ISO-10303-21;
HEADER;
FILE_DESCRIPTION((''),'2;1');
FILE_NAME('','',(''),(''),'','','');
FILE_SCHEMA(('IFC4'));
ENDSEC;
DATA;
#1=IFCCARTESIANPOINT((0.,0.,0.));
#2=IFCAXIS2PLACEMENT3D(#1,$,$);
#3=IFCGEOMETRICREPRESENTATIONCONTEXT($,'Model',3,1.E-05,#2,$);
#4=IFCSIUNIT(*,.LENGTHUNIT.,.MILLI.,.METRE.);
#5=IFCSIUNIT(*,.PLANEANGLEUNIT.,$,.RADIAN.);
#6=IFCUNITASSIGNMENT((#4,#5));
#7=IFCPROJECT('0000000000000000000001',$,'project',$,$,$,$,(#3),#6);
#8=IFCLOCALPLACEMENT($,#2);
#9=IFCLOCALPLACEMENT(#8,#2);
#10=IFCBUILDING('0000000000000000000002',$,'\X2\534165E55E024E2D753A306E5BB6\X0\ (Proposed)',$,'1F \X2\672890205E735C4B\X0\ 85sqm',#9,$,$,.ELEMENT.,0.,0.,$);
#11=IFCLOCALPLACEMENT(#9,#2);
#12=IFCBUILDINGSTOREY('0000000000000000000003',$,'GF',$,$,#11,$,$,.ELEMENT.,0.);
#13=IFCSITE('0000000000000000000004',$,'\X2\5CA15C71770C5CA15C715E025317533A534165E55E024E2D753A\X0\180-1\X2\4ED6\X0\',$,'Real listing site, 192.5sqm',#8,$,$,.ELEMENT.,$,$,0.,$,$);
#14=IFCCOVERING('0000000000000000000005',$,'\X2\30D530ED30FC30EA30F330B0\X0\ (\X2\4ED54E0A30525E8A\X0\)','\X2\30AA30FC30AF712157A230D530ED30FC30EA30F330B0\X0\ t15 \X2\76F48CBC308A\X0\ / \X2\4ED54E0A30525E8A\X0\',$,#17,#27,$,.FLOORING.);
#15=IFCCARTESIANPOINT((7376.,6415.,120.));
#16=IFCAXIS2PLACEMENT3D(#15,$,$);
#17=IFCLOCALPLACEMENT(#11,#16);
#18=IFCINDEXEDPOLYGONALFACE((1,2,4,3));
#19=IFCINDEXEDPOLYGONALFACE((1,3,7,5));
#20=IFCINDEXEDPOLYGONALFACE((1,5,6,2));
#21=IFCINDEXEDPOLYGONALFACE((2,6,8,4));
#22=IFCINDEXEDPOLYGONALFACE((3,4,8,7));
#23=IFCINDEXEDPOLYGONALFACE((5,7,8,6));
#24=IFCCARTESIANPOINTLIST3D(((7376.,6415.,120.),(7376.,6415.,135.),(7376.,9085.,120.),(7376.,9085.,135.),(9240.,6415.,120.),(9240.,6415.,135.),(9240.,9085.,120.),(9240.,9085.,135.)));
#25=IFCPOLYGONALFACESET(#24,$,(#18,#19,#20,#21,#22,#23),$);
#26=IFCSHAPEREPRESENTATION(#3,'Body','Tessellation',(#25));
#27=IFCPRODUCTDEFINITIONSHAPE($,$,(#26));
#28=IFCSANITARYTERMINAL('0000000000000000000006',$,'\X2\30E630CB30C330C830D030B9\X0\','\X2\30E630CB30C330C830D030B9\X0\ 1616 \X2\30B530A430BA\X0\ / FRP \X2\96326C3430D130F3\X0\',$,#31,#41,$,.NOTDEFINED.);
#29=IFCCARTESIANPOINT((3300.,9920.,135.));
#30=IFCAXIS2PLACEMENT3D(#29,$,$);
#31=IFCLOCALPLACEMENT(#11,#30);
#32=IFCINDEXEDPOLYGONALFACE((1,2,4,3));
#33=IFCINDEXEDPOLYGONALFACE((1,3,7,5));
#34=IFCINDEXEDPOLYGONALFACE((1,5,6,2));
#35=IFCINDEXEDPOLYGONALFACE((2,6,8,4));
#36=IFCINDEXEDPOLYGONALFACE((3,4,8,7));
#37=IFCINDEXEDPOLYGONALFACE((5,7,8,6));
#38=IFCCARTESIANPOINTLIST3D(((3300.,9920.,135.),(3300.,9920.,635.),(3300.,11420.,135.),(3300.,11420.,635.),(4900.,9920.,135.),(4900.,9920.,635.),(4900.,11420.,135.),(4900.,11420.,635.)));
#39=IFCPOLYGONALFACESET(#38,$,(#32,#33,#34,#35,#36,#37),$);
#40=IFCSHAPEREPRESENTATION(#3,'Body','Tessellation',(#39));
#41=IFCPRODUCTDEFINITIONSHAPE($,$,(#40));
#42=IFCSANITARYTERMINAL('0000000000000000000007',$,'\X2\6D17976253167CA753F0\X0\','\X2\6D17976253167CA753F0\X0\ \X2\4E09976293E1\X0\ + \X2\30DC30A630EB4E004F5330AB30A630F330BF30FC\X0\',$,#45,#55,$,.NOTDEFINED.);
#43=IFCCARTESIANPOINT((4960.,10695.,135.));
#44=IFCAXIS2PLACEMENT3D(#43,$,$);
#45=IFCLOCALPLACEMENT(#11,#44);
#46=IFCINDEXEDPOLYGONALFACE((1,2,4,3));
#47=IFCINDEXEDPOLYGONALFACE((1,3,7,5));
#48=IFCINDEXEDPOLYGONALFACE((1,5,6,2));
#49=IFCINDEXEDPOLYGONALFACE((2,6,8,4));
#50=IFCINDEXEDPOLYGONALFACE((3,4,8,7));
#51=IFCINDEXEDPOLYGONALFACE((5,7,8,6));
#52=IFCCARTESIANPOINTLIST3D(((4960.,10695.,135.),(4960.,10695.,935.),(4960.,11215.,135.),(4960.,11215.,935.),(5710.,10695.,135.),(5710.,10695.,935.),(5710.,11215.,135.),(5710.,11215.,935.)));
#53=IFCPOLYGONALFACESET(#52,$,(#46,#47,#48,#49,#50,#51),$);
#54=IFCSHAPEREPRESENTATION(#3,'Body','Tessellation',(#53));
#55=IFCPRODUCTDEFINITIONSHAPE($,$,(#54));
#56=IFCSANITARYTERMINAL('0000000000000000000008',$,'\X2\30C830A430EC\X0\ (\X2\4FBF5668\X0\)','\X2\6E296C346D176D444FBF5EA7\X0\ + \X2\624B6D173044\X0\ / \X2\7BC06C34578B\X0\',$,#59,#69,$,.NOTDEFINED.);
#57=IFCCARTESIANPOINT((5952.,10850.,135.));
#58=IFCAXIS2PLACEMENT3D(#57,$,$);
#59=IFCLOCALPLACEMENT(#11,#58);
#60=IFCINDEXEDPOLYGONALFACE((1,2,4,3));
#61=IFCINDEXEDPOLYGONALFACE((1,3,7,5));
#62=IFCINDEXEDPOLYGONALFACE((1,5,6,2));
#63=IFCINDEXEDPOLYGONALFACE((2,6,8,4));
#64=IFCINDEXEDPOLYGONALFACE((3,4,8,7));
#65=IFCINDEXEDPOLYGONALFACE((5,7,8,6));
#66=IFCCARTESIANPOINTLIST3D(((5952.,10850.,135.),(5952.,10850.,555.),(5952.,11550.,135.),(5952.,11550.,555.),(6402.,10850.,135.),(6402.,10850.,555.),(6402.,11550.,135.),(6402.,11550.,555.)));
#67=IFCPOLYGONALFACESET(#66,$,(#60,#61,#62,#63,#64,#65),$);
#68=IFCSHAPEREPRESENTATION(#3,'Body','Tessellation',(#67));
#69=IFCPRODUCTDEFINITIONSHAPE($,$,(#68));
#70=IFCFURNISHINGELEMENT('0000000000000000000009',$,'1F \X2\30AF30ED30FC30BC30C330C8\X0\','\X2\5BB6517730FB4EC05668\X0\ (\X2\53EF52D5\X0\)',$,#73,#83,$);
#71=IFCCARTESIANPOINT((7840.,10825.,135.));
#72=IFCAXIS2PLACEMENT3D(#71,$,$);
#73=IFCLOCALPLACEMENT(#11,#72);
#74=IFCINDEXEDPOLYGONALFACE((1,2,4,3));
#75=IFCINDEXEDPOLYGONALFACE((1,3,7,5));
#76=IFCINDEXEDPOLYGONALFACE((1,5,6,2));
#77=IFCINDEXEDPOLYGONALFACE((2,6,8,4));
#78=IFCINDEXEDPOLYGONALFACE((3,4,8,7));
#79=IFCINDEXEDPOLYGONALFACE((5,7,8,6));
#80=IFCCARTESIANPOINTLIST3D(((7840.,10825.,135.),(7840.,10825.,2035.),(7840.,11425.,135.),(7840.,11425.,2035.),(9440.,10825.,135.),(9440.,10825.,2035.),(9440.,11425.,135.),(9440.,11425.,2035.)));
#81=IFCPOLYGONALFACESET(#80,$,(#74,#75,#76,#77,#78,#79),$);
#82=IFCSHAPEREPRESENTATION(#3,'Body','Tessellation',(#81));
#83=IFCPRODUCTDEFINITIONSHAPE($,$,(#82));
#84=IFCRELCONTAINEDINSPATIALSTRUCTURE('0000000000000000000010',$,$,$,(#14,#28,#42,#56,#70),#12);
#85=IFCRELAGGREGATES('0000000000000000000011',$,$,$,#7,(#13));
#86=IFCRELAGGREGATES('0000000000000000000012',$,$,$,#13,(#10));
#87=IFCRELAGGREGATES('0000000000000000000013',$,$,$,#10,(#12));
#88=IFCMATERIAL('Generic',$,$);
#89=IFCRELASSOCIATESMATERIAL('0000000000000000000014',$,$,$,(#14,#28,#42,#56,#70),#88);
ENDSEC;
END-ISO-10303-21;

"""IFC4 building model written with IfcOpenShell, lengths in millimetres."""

from ifc_helpers import new_model, si_unit, frame, frame_2d, origin, place, context, project, spatial, rectangle, extrude, material, element, save


model = new_model("IFC4")

# Units and contexts
model_context = context("Model", 3, precision=1e-05, world=origin())
ifc_project = project(units=[si_unit("LENGTHUNIT", "METRE", prefix="MILLI"), si_unit("PLANEANGLEUNIT", "RADIAN")], contexts=[model_context])

# Site, building, storey
site_placement = place(None, origin())
site = spatial("IfcSite", under=ifc_project, at=site_placement, Name="岡山県岡山市北区十日市中町180-1他", ObjectType="Real listing site, 192.5sqm", CompositionType="ELEMENT", RefElevation=0.0)
building_placement = place(site_placement, origin())
building = spatial("IfcBuilding", under=site, at=building_placement, Name="十日市中町の家 (Proposed)", ObjectType="1F 木造平屋 85sqm", CompositionType="ELEMENT", ElevationOfRefHeight=0.0, ElevationOfTerrain=0.0)
storey_placement = place(building_placement, origin())
storey = spatial("IfcBuildingStorey", under=building, at=storey_placement, Name="GF", CompositionType="ELEMENT", Elevation=0.0)

# Covering
ifc_material_1 = material(Name="Generic")
covering_1_placement = place(storey_placement, frame((7376.0, 6415.0, 120.0)))
element("IfcCovering", 1, at=covering_1_placement, inside=storey, material=ifc_material_1, Name="フローリング (仕上げ床)", Description="オーク無垢フローリング t15 直貼り / 仕上げ床", PredefinedType="FLOORING", context=model_context, shape_type="SweptSolid", body=[
    extrude(rectangle(XDim=1864.0, YDim=2670.0, at=frame_2d((932.0, 1335.0))), frame((7376.0, 6415.0, 120.0)), (0.0, 0.0, 1.0), 15.0),
])

# Sanitary terminals
sanitary_terminal_1_placement = place(storey_placement, frame((3300.0, 9920.0, 135.0)))
element("IfcSanitaryTerminal", 2, at=sanitary_terminal_1_placement, inside=storey, material=ifc_material_1, Name="ユニットバス", Description="ユニットバス 1616 サイズ / FRP 防水パン", PredefinedType="NOTDEFINED", context=model_context, shape_type="SweptSolid", body=[
    extrude(rectangle(XDim=1600.0, YDim=1500.0, at=frame_2d((800.0, 750.0))), frame((3300.0, 9920.0, 135.0)), (0.0, 0.0, 1.0), 500.0),
])
sanitary_terminal_2_placement = place(storey_placement, frame((4960.0, 10695.0, 135.0)))
element("IfcSanitaryTerminal", 3, at=sanitary_terminal_2_placement, inside=storey, material=ifc_material_1, Name="洗面化粧台", Description="洗面化粧台 三面鏡 + ボウル一体カウンター", PredefinedType="NOTDEFINED", context=model_context, shape_type="SweptSolid", body=[
    extrude(rectangle(XDim=750.0, YDim=520.0, at=frame_2d((375.0, 260.0))), frame((4960.0, 10695.0, 135.0)), (0.0, 0.0, 1.0), 800.0),
])
sanitary_terminal_3_placement = place(storey_placement, frame((5952.0, 10850.0, 135.0)))
element("IfcSanitaryTerminal", 4, at=sanitary_terminal_3_placement, inside=storey, material=ifc_material_1, Name="トイレ (便器)", Description="温水洗浄便座 + 手洗い / 節水型", PredefinedType="NOTDEFINED", context=model_context, shape_type="SweptSolid", body=[
    extrude(rectangle(XDim=450.0, YDim=700.0, at=frame_2d((225.0, 350.0))), frame((5952.0, 10850.0, 135.0)), (0.0, 0.0, 1.0), 420.0),
])

# Furnishing element
furnishing_placement = place(storey_placement, frame((7840.0, 10825.0, 135.0)))
element("IfcFurnishingElement", 5, at=furnishing_placement, inside=storey, material=ifc_material_1, Name="1F クローゼット", Description="家具・什器 (可動)", context=model_context, shape_type="SweptSolid", body=[
    extrude(rectangle(XDim=1600.0, YDim=600.0, at=frame_2d((800.0, 300.0))), frame((7840.0, 10825.0, 135.0)), (0.0, 0.0, 1.0), 1900.0),
])

save(model, "model.ifc")
